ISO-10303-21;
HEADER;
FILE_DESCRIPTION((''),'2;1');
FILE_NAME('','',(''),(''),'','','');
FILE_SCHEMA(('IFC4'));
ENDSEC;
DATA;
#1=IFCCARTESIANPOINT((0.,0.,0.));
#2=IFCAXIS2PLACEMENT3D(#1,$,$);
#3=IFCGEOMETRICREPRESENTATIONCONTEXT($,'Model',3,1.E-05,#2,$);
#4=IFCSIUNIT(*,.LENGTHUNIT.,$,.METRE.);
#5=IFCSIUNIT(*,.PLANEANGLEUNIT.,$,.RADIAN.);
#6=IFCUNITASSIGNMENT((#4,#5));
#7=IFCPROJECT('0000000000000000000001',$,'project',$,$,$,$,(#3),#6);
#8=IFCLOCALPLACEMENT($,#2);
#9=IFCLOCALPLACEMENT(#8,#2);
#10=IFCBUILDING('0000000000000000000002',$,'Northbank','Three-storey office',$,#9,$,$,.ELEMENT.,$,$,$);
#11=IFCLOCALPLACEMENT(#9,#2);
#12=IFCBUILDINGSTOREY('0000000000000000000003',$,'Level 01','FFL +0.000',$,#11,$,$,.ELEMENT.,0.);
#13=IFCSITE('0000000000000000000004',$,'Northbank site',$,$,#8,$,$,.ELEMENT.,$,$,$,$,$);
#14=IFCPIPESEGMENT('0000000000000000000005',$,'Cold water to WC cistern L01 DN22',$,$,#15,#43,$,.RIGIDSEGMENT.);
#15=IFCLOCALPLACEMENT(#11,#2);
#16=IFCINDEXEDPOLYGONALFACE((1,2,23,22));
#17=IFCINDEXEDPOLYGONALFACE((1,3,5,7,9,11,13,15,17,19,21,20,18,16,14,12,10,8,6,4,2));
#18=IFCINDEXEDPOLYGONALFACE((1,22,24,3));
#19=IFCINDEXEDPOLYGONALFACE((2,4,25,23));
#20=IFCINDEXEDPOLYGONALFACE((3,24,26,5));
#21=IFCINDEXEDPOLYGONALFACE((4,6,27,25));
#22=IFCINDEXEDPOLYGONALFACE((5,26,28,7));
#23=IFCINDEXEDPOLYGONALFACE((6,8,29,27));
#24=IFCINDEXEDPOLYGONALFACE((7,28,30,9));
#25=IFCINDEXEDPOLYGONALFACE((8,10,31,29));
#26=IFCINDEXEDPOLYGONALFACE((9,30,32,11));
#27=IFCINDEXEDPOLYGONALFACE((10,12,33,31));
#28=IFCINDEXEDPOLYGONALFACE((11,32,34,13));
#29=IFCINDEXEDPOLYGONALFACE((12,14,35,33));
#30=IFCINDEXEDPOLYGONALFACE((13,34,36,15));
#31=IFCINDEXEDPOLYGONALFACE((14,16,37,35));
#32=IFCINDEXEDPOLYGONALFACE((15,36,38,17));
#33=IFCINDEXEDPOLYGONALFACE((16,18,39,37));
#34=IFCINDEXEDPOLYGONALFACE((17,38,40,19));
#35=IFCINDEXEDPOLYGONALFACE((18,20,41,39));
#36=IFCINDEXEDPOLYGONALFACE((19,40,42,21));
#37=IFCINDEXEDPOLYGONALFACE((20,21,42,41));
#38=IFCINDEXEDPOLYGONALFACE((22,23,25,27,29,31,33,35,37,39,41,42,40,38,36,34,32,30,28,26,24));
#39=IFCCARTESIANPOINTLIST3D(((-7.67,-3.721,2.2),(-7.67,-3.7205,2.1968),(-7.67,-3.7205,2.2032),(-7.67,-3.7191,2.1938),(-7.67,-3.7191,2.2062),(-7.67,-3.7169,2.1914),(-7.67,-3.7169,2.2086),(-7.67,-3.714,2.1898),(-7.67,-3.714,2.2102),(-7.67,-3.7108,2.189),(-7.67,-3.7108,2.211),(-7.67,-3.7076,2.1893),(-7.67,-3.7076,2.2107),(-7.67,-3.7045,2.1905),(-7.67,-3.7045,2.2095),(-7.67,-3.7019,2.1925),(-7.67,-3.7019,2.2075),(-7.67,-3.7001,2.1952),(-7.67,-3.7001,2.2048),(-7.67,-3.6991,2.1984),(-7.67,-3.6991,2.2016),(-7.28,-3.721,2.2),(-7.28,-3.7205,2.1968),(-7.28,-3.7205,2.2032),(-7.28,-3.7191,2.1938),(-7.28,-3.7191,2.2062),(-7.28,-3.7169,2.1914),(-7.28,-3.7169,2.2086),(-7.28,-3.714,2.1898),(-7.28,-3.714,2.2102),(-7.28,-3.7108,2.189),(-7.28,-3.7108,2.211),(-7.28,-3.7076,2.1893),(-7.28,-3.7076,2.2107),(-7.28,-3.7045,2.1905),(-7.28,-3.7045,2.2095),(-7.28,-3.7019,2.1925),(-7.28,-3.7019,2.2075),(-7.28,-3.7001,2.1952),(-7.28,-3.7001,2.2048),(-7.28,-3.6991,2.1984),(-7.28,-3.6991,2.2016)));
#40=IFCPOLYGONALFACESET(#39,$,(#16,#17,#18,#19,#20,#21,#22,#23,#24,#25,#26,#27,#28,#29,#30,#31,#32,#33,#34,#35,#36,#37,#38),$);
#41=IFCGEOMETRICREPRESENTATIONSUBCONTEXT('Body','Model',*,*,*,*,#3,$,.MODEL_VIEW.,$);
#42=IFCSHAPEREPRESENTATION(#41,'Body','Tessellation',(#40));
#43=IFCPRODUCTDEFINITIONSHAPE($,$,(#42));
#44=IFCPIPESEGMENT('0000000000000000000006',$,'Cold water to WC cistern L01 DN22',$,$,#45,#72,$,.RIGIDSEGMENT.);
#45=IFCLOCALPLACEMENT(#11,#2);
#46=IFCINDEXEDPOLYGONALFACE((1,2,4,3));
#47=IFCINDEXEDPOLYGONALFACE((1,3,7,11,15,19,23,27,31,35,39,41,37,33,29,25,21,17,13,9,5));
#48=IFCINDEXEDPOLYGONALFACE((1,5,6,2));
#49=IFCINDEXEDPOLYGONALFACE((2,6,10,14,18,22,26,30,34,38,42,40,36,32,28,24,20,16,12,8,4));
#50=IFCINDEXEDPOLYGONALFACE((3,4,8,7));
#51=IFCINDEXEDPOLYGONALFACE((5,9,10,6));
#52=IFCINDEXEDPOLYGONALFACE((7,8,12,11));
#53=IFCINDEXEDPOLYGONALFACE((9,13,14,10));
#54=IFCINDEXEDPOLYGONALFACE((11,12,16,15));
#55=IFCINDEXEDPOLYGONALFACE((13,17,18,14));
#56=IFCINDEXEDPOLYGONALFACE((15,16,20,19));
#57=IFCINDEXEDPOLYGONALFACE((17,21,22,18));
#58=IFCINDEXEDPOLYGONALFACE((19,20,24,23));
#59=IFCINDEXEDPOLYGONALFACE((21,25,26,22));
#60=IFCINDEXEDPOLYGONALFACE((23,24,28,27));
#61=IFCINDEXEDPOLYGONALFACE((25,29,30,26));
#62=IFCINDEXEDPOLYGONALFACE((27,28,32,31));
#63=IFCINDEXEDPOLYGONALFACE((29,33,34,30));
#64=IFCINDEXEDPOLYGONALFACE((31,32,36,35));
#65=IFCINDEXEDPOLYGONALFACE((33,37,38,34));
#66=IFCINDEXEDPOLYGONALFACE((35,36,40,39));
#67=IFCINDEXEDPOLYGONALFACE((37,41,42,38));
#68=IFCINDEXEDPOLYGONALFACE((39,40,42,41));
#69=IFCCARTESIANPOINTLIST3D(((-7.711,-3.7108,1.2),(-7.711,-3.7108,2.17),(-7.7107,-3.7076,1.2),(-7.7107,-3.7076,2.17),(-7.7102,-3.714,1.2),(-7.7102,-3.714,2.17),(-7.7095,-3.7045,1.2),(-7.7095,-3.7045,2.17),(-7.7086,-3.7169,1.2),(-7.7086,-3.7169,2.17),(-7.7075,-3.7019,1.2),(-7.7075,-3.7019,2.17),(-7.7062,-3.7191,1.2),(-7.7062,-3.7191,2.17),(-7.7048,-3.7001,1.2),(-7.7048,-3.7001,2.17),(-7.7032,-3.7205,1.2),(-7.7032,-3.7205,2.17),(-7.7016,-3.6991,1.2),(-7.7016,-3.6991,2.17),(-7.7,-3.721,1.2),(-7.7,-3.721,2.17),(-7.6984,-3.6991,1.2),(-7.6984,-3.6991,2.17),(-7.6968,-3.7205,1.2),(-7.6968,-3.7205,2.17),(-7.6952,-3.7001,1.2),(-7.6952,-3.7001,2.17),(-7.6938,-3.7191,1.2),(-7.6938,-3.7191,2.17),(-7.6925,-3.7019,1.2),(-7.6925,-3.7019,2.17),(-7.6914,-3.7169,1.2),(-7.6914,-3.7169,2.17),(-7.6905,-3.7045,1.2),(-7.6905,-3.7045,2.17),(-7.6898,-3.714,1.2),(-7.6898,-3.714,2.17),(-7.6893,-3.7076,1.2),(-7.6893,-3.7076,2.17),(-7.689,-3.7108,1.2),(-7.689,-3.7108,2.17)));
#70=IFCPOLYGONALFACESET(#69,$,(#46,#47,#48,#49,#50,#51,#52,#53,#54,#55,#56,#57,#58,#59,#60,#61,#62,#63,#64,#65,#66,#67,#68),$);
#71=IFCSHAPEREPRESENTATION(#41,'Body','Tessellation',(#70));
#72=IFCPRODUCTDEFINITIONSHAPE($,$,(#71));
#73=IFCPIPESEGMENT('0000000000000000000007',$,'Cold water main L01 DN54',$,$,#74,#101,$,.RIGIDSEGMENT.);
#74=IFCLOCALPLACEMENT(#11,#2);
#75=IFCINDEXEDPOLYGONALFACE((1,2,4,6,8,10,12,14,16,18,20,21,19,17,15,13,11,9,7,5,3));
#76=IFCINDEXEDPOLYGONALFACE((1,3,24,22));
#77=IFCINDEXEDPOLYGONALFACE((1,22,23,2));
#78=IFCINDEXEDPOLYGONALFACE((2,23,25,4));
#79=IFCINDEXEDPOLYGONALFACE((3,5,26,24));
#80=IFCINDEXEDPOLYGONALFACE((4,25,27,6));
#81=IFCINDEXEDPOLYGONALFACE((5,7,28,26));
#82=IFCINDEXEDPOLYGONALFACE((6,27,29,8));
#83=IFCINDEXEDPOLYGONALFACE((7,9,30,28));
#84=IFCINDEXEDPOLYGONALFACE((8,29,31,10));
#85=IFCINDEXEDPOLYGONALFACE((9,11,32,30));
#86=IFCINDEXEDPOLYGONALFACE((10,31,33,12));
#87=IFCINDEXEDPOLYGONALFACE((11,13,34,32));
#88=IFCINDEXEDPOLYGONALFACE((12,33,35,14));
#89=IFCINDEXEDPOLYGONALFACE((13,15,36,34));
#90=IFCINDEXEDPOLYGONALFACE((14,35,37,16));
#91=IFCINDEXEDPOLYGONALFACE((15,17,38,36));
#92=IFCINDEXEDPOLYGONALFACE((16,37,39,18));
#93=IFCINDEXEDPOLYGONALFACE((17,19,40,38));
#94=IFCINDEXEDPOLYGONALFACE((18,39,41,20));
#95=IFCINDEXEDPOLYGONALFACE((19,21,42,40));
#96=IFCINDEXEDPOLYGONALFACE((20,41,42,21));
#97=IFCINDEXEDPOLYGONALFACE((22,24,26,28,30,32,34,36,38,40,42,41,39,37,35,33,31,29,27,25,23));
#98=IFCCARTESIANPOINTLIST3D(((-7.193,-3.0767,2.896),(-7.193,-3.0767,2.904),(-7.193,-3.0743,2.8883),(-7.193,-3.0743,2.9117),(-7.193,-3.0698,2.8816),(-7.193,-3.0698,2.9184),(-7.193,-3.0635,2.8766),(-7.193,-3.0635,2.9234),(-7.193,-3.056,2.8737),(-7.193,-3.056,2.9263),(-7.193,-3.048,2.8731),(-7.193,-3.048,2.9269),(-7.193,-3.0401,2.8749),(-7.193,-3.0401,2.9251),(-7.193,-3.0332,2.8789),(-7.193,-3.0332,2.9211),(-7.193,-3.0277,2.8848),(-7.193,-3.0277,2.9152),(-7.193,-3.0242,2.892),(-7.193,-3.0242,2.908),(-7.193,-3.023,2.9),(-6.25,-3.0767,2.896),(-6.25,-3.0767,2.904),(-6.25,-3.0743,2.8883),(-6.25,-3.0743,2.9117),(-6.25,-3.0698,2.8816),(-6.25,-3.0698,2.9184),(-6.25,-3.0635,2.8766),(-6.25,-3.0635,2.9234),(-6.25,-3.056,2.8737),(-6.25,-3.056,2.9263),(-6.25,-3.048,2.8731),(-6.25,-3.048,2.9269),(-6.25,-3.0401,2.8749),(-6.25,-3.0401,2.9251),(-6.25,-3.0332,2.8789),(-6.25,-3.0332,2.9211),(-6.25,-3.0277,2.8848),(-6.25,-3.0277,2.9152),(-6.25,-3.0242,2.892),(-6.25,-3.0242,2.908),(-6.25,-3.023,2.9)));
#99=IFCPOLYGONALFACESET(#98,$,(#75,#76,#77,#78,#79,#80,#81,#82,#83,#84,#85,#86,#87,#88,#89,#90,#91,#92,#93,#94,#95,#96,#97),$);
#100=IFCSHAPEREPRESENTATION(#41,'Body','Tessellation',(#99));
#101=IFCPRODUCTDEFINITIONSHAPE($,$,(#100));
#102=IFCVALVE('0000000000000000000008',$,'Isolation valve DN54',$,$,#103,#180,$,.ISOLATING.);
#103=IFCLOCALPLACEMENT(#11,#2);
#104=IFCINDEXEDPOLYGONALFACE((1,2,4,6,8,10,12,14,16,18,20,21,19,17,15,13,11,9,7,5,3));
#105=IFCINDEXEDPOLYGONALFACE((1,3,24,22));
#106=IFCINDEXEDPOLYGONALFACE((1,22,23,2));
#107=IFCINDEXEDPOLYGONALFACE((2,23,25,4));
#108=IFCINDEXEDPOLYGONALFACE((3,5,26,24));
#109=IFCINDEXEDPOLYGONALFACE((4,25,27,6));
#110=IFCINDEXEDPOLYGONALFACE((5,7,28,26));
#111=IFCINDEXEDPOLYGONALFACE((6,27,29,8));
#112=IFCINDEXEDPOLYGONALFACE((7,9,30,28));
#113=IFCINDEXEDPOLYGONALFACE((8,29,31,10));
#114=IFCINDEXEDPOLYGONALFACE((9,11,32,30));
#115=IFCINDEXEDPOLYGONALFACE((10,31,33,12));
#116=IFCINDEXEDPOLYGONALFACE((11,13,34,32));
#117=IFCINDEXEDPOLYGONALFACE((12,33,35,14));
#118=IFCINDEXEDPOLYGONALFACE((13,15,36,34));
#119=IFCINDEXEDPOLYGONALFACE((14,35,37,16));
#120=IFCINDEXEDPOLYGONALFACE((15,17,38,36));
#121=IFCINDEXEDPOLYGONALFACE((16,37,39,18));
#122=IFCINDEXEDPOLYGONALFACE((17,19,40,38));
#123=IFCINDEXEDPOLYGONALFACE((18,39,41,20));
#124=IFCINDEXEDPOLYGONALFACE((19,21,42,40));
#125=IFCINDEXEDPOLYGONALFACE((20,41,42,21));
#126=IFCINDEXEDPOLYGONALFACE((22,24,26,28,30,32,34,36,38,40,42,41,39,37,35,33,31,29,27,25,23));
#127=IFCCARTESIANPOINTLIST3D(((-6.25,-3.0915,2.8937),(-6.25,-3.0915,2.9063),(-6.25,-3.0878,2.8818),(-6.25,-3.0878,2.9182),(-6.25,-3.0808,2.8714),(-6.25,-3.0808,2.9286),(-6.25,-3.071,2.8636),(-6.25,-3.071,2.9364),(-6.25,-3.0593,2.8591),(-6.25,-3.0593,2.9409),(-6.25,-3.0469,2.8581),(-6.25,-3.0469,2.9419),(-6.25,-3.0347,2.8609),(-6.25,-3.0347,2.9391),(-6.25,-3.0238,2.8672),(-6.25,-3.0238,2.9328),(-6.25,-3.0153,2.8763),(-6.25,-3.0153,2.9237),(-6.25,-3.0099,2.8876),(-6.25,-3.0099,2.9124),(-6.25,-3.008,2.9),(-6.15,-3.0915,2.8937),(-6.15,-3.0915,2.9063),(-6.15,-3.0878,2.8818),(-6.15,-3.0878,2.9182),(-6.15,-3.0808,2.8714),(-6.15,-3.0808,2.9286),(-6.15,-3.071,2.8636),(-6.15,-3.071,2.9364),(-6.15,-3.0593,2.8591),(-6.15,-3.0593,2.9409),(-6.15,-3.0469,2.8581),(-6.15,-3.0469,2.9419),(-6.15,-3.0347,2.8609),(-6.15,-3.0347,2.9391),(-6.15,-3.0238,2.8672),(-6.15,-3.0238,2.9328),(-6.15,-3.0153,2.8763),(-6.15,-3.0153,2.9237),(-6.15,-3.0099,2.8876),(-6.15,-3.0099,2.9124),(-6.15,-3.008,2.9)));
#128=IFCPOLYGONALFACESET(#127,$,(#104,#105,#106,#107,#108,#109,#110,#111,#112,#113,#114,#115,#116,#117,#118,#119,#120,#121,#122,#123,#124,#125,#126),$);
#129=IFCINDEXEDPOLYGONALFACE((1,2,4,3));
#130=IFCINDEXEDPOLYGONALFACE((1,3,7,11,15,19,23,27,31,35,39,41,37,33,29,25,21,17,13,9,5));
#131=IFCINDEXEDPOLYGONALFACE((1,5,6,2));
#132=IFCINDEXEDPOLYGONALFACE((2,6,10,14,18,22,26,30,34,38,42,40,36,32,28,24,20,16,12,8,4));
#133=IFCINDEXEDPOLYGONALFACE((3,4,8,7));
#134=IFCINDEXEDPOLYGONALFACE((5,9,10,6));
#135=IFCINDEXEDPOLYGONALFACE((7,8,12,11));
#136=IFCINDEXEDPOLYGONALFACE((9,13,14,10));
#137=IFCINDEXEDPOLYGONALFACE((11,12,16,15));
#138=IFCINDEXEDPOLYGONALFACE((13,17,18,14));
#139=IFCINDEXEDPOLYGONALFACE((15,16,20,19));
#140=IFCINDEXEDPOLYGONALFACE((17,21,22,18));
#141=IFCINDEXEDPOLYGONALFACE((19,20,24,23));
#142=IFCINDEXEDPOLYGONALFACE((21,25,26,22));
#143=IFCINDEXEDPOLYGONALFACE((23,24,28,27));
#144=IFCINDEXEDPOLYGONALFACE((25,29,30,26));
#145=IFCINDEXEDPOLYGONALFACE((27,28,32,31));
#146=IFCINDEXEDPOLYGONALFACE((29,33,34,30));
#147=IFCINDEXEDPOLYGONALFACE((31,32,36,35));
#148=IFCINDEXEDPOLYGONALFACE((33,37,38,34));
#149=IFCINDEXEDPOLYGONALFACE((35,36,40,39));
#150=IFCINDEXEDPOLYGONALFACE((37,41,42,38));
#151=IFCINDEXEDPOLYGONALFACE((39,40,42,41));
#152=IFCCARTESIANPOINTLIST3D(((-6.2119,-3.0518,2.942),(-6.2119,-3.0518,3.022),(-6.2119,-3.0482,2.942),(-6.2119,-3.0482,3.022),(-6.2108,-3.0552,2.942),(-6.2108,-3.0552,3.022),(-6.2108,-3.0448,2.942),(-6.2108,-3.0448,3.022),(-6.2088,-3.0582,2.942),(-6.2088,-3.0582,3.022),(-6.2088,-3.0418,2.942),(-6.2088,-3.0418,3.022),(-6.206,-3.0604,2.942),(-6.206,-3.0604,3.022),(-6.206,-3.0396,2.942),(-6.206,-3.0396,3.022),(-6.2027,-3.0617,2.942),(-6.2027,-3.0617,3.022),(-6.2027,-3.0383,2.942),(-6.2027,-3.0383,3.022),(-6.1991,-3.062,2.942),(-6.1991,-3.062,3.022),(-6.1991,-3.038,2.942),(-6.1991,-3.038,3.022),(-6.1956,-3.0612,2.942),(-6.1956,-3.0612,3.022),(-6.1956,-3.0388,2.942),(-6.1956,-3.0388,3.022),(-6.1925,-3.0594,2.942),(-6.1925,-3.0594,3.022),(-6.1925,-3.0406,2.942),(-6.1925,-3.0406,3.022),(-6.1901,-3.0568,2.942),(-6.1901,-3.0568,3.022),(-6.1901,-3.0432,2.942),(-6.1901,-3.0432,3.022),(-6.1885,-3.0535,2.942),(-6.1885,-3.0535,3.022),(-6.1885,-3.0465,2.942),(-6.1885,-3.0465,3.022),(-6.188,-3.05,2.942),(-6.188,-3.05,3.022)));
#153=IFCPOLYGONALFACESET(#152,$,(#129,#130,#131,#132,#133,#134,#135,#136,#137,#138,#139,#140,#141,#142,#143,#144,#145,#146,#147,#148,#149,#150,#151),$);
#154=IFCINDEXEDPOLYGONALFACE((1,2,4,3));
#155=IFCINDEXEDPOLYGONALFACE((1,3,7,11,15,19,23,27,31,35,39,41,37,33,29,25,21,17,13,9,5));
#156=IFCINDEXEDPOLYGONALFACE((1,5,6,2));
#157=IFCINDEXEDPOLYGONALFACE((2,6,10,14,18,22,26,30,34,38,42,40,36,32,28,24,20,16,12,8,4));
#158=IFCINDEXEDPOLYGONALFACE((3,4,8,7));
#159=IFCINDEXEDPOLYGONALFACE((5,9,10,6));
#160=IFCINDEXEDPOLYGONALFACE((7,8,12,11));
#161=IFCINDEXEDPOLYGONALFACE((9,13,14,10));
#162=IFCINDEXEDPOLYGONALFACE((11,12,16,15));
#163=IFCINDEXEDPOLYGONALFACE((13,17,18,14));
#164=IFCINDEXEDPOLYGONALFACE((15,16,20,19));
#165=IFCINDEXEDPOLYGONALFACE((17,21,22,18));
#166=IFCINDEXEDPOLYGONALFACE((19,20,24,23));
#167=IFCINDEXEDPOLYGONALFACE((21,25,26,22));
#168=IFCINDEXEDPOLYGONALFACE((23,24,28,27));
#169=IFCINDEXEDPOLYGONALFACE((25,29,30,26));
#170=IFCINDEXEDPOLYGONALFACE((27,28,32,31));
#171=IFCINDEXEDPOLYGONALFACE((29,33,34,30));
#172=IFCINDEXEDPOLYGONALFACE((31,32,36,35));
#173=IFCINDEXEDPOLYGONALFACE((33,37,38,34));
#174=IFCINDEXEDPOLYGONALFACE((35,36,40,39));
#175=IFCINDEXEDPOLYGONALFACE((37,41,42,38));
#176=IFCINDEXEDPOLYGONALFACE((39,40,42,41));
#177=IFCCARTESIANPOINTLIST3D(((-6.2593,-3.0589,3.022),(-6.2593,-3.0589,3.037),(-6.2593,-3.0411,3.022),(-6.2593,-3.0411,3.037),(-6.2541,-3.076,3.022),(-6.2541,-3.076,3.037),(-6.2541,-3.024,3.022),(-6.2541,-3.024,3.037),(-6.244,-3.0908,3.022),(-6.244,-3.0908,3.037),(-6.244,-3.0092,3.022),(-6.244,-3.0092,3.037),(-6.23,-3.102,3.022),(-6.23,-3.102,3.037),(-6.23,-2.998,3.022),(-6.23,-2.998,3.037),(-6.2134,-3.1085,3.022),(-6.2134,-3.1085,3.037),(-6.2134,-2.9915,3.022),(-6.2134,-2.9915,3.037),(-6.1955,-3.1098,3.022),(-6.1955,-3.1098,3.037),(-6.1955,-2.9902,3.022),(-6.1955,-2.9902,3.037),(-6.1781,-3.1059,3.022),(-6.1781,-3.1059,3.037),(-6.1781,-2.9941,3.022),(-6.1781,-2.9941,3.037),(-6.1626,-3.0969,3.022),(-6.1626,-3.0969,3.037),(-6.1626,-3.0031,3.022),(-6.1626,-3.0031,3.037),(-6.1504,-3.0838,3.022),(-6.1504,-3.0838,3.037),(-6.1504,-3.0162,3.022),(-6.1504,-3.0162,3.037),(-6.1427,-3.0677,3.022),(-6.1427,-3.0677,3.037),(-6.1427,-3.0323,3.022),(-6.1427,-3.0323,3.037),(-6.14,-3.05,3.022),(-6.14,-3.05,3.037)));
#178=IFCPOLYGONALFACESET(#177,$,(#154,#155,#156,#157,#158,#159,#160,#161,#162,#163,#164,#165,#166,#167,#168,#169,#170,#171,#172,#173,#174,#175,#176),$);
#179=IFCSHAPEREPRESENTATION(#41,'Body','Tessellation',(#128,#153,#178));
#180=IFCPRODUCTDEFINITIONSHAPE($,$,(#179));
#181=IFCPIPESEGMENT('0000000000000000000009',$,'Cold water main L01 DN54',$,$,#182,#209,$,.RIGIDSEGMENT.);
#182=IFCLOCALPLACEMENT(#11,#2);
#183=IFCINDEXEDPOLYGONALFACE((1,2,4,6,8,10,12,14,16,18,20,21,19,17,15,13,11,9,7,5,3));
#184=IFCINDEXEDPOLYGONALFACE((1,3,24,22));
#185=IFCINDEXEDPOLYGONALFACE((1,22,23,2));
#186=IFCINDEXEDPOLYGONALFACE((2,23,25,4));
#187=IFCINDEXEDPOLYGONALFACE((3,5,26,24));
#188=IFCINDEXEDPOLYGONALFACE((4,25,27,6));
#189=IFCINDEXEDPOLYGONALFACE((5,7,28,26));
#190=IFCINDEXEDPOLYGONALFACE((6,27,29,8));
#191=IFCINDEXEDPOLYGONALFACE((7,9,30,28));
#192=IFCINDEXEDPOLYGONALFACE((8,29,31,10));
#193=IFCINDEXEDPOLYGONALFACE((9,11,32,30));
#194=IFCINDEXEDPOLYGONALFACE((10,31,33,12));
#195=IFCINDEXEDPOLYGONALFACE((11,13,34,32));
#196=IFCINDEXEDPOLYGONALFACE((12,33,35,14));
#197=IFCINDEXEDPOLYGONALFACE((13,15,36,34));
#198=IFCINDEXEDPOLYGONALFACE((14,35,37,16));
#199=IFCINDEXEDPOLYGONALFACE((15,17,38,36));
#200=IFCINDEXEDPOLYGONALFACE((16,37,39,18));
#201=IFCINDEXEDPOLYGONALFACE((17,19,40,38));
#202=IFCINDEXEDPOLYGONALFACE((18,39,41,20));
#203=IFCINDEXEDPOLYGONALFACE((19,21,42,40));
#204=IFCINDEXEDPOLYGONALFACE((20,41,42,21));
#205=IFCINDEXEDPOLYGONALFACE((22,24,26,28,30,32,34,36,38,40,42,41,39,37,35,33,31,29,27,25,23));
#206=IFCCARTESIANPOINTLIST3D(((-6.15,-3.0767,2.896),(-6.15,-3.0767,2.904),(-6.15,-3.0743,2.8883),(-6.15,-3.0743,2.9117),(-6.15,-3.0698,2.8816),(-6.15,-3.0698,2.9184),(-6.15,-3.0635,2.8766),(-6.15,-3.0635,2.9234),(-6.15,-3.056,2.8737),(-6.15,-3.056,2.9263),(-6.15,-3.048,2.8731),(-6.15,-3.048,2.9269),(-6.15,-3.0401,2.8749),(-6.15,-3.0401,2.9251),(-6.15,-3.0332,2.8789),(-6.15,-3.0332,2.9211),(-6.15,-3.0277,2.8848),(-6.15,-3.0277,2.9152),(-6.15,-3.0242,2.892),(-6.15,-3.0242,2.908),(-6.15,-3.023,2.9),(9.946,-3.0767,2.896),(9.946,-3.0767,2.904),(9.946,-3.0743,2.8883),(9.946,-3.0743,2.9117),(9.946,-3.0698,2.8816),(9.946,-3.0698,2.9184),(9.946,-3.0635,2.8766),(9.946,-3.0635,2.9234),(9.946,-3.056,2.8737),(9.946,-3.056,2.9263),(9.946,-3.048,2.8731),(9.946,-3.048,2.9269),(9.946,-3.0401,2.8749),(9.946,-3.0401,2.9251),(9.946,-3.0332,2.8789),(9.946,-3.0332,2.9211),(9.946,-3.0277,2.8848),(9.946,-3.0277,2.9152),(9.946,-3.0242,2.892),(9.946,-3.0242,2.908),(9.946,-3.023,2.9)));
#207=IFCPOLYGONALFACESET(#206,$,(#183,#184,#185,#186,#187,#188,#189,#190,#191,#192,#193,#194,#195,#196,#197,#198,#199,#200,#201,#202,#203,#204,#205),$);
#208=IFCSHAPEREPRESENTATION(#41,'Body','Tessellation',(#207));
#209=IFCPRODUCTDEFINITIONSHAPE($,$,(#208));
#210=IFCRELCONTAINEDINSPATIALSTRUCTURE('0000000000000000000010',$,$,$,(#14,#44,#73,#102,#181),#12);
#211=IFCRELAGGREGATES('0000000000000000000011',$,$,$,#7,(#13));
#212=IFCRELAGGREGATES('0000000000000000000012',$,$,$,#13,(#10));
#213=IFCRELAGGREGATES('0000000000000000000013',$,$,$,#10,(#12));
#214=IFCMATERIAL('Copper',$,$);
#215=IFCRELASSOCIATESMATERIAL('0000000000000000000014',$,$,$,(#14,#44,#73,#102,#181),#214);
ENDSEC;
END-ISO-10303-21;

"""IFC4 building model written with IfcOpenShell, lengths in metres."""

from ifc_helpers import new_model, si_unit, frame, origin, place, context, subcontext, project, spatial, circle, extrude, material, element, save


model = new_model("IFC4")

# Units and contexts
model_context = context("Model", 3, precision=1e-05, world=origin())
body_context = subcontext(model_context, "Body", "Model", "MODEL_VIEW")
ifc_project = project(units=[si_unit("LENGTHUNIT", "METRE"), si_unit("PLANEANGLEUNIT", "RADIAN")], contexts=[model_context])

# Site, building, storey
site_placement = place(None, origin())
site = spatial("IfcSite", under=ifc_project, at=site_placement, Name="Northbank site", CompositionType="ELEMENT")
building_placement = place(site_placement, origin())
building = spatial("IfcBuilding", under=site, at=building_placement, Name="Northbank", Description="Three-storey office", CompositionType="ELEMENT")
storey_placement = place(building_placement, origin())
storey = spatial("IfcBuildingStorey", under=building, at=storey_placement, Name="Level 01", Description="FFL +0.000", CompositionType="ELEMENT", Elevation=0.0)

# Shared definitions
ifc_material = material(Name="Copper")

# Pipe segments
pipe_segment_1_placement = place(storey_placement, origin())
element("IfcPipeSegment", 1, at=pipe_segment_1_placement, inside=storey, material=ifc_material, Name="Cold water to WC cistern L01 DN22", PredefinedType="RIGIDSEGMENT", context=body_context, shape_type="SweptSolid", body=[
    extrude(circle(Radius=0.011), frame((-7.28, -3.71, 2.2), z_axis=(-1.0, 0.0, 0.0), x_axis=(0.0, -1.0, 0.0)), (0.0, 0.0, 1.0), 0.39),
])
pipe_segment_2_placement = place(storey_placement, origin())
element("IfcPipeSegment", 2, at=pipe_segment_2_placement, inside=storey, material=ifc_material, Name="Cold water to WC cistern L01 DN22", PredefinedType="RIGIDSEGMENT", context=body_context, shape_type="SweptSolid", body=[
    extrude(circle(Radius=0.011), frame((-7.7, -3.71, 2.17), z_axis=(0.0, 0.0, -1.0), x_axis=(0.0, -1.0, 0.0)), (0.0, 0.0, 1.0), 0.97),
])
pipe_segment_3_placement = place(storey_placement, origin())
element("IfcPipeSegment", 3, at=pipe_segment_3_placement, inside=storey, material=ifc_material, Name="Cold water main L01 DN54", PredefinedType="RIGIDSEGMENT", context=body_context, shape_type="SweptSolid", body=[
    extrude(circle(Radius=0.027), frame((-7.193, -3.05, 2.9), z_axis=(1.0, 0.0, 0.0), x_axis=(0.0, 1.0, 0.0)), (0.0, 0.0, 1.0), 0.943),
])

# Valve
valve_placement = place(storey_placement, origin())
element("IfcValve", 4, at=valve_placement, inside=storey, material=ifc_material, Name="Isolation valve DN54", PredefinedType="ISOLATING", context=body_context, shape_type="SweptSolid", body=[
    extrude(circle(Radius=0.042), frame((-6.25, -3.05, 2.9), z_axis=(1.0, 0.0, 0.0), x_axis=(0.0, 1.0, 0.0)), (0.0, 0.0, 1.0), 0.1),
    extrude(circle(Radius=0.012), frame((-6.2, -3.05, 2.942), z_axis=(0.0, 0.0, 1.0), x_axis=(1.0, 0.0, 0.0)), (0.0, 0.0, 1.0), 0.08),
    extrude(circle(Radius=0.06), frame((-6.2, -3.05, 3.022), z_axis=(0.0, 0.0, 1.0), x_axis=(1.0, 0.0, 0.0)), (0.0, 0.0, 1.0), 0.015),
])

# Pipe segment
pipe_segment_4_placement = place(storey_placement, origin())
element("IfcPipeSegment", 5, at=pipe_segment_4_placement, inside=storey, material=ifc_material, Name="Cold water main L01 DN54", PredefinedType="RIGIDSEGMENT", context=body_context, shape_type="SweptSolid", body=[
    extrude(circle(Radius=0.027), frame((-6.15, -3.05, 2.9), z_axis=(1.0, 0.0, 0.0), x_axis=(0.0, 1.0, 0.0)), (0.0, 0.0, 1.0), 16.096),
])

save(model, "model.ifc")
